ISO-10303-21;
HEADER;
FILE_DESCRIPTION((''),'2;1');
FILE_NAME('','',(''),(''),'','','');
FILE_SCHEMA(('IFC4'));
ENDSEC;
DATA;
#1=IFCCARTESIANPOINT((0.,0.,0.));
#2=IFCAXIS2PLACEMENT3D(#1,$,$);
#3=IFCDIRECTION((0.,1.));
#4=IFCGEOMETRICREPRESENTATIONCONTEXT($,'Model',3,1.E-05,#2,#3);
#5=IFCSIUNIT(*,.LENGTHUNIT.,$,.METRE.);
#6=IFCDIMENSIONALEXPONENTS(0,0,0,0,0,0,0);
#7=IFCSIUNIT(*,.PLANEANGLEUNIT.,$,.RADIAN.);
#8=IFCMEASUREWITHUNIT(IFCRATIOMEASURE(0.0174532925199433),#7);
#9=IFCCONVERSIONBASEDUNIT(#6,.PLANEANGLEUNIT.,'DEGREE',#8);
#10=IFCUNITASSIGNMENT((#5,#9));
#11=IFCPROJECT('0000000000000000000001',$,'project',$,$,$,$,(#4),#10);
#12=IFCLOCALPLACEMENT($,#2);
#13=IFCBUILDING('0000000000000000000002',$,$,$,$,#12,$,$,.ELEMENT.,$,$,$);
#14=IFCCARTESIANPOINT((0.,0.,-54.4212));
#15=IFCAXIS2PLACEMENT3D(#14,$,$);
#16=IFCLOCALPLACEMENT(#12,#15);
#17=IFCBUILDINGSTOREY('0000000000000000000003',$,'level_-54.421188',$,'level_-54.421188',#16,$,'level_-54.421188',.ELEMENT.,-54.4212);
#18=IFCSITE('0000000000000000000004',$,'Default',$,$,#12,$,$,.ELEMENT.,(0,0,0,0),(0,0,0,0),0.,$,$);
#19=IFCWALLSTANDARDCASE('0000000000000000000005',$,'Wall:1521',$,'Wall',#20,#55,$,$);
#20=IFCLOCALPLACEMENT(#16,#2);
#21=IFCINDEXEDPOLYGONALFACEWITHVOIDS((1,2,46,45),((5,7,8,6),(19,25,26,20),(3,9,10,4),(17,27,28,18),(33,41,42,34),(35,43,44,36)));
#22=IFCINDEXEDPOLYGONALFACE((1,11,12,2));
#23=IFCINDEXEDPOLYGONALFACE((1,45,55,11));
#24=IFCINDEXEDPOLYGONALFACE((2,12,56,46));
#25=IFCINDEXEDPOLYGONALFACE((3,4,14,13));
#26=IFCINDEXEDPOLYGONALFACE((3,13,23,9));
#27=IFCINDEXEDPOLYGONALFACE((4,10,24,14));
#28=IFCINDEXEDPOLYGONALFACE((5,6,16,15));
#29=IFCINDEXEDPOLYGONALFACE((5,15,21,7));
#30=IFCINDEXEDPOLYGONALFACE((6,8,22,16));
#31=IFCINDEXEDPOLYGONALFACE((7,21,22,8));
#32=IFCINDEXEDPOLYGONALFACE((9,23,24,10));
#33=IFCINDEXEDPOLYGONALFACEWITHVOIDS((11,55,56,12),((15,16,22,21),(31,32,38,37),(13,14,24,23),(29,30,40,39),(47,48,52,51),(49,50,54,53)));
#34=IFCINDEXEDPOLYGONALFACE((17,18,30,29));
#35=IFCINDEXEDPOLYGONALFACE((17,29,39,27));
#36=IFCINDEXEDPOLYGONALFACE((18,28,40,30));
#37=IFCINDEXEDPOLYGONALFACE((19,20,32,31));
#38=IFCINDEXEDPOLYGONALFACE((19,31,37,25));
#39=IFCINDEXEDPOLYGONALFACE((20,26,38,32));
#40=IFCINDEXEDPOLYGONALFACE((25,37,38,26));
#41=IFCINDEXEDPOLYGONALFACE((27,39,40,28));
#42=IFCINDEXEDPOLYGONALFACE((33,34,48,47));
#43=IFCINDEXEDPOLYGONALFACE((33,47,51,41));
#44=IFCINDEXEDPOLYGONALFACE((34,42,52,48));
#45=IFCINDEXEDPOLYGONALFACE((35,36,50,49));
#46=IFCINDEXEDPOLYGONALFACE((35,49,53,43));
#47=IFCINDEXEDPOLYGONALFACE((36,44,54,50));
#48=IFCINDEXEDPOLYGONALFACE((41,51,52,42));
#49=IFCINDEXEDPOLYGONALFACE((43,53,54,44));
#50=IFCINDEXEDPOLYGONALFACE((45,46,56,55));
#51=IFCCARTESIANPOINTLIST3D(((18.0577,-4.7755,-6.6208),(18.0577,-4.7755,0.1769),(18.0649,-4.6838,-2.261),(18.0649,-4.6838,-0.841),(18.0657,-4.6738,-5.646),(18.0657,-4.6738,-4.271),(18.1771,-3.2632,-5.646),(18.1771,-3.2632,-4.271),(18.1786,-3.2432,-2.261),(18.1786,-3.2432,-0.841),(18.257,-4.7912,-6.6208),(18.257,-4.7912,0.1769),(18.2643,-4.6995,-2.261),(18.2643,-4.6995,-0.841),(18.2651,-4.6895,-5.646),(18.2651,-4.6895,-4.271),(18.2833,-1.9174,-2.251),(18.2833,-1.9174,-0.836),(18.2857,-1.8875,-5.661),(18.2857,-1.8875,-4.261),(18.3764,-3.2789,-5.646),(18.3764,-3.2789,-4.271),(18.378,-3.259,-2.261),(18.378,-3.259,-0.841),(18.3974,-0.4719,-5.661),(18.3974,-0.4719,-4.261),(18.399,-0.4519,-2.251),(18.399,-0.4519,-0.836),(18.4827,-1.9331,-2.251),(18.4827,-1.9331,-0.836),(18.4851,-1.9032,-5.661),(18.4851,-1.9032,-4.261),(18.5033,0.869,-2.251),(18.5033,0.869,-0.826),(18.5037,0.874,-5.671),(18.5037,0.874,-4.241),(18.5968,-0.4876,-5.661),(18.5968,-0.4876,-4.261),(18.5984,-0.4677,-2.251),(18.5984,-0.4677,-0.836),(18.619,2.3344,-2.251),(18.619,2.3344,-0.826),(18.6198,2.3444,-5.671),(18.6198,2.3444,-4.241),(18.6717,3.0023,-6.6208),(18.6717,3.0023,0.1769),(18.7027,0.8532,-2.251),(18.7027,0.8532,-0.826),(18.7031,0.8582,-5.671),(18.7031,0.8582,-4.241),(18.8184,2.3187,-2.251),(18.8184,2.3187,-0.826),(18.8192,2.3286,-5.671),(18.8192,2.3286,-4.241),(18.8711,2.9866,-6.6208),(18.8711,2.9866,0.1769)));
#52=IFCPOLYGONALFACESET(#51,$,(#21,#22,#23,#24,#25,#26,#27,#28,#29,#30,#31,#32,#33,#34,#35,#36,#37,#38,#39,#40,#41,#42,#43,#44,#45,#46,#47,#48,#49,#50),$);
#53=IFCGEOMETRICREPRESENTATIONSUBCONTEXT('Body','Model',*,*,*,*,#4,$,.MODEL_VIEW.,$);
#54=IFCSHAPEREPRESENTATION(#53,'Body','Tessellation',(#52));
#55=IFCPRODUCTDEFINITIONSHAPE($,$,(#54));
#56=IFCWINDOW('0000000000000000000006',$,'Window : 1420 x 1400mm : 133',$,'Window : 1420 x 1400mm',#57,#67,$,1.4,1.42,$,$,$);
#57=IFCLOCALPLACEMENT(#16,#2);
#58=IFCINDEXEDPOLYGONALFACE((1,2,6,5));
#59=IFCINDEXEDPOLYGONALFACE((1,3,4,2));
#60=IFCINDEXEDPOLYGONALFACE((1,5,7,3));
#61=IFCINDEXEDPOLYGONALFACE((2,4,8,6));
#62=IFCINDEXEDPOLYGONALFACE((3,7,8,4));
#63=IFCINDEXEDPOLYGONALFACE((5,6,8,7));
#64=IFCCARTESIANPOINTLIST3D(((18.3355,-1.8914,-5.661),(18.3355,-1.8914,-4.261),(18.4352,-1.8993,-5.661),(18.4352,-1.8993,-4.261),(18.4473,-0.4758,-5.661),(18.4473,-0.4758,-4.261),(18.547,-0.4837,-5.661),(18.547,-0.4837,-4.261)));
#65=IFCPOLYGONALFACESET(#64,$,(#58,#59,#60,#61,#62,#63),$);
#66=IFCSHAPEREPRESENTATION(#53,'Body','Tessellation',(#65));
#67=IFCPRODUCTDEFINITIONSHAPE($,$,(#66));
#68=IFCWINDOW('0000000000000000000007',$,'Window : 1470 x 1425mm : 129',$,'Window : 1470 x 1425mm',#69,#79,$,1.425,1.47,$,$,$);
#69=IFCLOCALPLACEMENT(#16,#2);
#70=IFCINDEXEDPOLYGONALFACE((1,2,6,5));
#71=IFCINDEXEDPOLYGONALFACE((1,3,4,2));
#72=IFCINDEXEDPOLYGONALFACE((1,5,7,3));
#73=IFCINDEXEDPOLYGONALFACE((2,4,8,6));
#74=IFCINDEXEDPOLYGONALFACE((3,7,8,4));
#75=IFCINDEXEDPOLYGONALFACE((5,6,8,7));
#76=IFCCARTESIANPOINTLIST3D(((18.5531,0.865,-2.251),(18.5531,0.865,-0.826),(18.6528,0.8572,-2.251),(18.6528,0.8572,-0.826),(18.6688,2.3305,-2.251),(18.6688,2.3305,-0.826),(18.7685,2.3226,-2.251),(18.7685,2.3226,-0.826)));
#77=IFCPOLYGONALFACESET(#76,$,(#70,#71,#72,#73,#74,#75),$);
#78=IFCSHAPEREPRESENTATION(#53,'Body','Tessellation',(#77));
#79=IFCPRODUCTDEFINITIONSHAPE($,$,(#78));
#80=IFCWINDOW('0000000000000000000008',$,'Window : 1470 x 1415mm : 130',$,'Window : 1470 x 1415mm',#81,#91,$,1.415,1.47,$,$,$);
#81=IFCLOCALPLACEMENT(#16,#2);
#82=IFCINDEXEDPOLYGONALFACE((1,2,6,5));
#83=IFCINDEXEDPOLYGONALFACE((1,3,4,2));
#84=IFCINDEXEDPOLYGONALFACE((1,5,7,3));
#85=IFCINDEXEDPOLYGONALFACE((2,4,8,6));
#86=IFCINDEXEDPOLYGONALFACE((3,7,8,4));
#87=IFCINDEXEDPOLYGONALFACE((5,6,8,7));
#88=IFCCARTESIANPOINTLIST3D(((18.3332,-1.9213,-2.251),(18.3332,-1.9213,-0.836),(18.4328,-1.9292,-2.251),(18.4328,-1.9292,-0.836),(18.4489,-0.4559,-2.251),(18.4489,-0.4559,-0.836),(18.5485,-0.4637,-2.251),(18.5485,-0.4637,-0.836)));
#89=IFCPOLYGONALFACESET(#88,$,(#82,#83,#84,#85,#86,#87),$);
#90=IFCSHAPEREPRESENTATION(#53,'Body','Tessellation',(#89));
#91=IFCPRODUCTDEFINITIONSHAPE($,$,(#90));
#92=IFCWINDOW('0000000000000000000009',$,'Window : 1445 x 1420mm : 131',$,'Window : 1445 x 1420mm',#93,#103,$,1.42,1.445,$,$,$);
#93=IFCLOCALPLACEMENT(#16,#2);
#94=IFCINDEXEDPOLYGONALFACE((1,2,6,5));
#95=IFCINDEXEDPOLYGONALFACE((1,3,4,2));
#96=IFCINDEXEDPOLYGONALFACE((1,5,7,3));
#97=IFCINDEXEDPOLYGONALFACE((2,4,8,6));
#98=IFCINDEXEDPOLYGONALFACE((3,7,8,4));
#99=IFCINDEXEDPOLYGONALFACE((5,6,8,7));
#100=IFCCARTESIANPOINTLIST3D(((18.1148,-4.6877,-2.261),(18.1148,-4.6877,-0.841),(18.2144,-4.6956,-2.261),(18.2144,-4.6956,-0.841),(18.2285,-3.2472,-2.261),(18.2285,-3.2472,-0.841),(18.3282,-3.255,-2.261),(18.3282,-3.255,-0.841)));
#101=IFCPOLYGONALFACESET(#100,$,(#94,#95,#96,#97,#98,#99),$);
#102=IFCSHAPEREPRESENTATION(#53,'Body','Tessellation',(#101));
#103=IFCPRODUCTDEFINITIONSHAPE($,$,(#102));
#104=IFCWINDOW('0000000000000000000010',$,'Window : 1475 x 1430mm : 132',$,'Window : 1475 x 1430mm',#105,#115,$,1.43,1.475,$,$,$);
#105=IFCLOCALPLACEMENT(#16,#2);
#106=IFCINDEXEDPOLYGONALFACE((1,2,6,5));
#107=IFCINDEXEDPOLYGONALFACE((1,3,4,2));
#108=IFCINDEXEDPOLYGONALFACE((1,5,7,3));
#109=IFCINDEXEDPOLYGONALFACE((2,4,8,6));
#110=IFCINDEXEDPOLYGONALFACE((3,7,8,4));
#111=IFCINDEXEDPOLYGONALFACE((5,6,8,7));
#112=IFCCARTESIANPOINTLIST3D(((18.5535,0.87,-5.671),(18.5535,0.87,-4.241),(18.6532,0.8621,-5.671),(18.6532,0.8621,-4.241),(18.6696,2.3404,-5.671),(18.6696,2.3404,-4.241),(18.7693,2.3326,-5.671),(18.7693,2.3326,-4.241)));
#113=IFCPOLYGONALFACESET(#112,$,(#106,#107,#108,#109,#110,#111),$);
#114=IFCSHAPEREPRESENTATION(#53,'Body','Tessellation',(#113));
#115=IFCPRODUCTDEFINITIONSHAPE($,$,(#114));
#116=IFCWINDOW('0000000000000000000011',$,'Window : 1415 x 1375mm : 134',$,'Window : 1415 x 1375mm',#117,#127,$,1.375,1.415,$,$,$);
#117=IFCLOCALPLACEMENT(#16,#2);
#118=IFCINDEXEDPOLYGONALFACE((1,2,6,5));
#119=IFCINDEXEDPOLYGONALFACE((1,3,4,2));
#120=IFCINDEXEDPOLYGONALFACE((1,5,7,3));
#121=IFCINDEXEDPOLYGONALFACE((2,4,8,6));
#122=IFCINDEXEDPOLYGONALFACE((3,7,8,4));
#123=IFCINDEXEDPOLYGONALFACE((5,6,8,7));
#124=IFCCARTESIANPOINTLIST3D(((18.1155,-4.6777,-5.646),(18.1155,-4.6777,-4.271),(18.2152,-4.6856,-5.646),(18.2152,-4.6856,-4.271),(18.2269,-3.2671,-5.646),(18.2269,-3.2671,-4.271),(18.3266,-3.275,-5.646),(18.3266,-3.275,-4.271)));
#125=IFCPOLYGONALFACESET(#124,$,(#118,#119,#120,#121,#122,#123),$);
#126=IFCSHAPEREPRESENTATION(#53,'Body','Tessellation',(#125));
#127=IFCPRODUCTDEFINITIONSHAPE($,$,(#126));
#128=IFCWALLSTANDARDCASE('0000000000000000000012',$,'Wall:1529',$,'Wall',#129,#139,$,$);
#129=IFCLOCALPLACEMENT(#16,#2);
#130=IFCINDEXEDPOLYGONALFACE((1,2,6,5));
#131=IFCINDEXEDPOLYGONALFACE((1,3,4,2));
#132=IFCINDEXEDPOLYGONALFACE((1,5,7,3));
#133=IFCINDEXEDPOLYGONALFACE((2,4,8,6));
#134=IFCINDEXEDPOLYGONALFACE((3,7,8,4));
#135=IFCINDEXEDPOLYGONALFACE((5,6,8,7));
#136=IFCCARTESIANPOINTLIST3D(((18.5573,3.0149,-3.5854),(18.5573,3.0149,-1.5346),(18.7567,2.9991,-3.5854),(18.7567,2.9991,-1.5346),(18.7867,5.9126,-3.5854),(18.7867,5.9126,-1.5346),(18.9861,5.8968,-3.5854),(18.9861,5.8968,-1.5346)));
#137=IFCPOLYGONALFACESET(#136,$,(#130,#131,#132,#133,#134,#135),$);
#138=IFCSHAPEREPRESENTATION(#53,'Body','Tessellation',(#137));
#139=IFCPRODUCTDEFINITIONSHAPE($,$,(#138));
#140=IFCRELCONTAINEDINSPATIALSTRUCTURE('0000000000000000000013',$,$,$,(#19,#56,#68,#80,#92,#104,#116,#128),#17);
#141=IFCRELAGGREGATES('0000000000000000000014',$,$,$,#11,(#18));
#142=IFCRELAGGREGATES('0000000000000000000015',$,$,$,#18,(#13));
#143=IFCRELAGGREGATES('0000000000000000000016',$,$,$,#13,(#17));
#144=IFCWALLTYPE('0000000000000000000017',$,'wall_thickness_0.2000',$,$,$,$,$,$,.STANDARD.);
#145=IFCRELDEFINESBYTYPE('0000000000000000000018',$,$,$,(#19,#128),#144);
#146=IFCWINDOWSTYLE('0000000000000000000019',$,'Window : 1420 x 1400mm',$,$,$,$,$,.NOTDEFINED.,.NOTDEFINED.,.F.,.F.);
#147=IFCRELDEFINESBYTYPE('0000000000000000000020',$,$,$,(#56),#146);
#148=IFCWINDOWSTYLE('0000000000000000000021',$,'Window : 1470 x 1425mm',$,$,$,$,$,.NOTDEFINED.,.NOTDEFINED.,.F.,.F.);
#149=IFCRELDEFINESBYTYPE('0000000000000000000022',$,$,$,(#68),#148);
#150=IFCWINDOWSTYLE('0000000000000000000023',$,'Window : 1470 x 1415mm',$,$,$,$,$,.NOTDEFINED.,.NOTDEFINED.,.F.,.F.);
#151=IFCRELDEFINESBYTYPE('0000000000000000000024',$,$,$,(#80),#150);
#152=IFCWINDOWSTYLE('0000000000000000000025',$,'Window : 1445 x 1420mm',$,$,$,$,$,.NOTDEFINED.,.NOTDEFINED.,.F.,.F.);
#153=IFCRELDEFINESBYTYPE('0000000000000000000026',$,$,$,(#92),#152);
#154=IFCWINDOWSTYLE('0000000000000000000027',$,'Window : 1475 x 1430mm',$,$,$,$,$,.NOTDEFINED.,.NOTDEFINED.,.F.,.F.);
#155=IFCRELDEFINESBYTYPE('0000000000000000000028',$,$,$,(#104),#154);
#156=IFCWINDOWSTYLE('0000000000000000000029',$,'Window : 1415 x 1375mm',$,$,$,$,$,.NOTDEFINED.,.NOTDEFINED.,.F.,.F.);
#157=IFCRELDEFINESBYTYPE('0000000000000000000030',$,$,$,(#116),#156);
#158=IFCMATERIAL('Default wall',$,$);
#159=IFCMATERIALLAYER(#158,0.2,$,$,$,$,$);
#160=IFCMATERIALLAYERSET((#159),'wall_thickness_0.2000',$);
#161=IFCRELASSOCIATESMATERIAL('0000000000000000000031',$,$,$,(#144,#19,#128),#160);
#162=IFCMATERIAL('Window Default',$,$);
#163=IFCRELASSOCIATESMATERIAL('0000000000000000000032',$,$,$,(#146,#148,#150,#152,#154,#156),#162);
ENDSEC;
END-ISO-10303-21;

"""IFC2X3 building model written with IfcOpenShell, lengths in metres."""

from ifc_helpers import new_model, entity, si_unit, converted_unit, direction, frame, frame_2d, origin, origin_2d_with_axis, place, context, subcontext, project, spatial, polyline, rectangle, outline, extrude, source, transform, mapped, material, layer, layer_set, layer_usage, type_object, type_shapes, element, fill, save


model = new_model("IFC2X3")

# Units and contexts
model_context = context("Model", 3, precision=1e-05, world=origin(), true_north=direction((0.0, 1.0)))
body_context = subcontext(model_context, "Body", "Model", "MODEL_VIEW")
ifc_project = project(units=[si_unit("LENGTHUNIT", "METRE"), converted_unit("PLANEANGLEUNIT", "DEGREE", entity("IfcRatioMeasure", 0.0174532925199433), si_unit("PLANEANGLEUNIT", "RADIAN"), dimensions=[0, 0, 0, 0, 0, 0, 0])], contexts=[model_context])

# Site, building, storey
placement_1 = place(None, origin())
site = spatial("IfcSite", under=ifc_project, at=placement_1, Name="Default", CompositionType="ELEMENT", RefLatitude=(0, 0, 0, 0), RefLongitude=(0, 0, 0, 0), RefElevation=0.0)
building = spatial("IfcBuilding", under=site, at=placement_1, CompositionType="ELEMENT")
storey_placement = place(placement_1, frame((0.0, 0.0, -54.4212)))
storey = spatial("IfcBuildingStorey", under=building, at=storey_placement, Name="level_-54.421188", ObjectType="level_-54.421188", LongName="level_-54.421188", CompositionType="ELEMENT", Elevation=-54.4212)

# Shared definitions
ifc_material_1 = material(Name="Default wall")
ifc_layer = layer(ifc_material_1, 0.2)
ifc_layer_set = layer_set([ifc_layer], Name="wall_thickness_0.2000")
ifc_layer_usage = layer_usage(ifc_layer_set, "AXIS2", "POSITIVE", -0.1)
wall_type = type_object("IfcWallType", Name="wall_thickness_0.2000", PredefinedType="STANDARD", material=ifc_layer_set)
ifc_material_2 = material(Name="Window Default")

# Wall, openings, windows
placement_2 = place(placement_1, frame((0.0, 0.0, -61.042)))
wall_1_placement = place(placement_2, frame((18.7714, 2.9945, 0.0), z_axis=(0.0, 0.0, 1.0), x_axis=(-0.078706, -0.996898, 0.0)))
wall_1 = element("IfcWallStandardCase", 1, at=wall_1_placement, inside=storey, type_object=wall_type, material=ifc_layer_usage, Name="Wall:1521", ObjectType="Wall", context=body_context, shape_type="SweptSolid", body=[
    extrude(outline(polyline([(7.802, -0.1), (7.802, 0.1), (0.0, 0.1), (0.0, -0.1), (7.802, -0.1)])), origin(), (0.0, 0.0, 1.0), 6.7978),
])
opening_1_placement = place(wall_1_placement, frame((0.67, -0.1, 4.3698)))
opening_1 = element("IfcOpeningElement", 2, at=opening_1_placement, cuts=wall_1, ObjectType="Opening", context=body_context, shape_type="SweptSolid", body=[
    extrude(rectangle(XDim=1.47, YDim=1.425, at=frame_2d((0.7125, 0.735), x_axis=(0.0, 1.0))), frame((0.0, 0.0, 0.0), z_axis=(0.0, 1.0, 0.0), x_axis=(0.0, 0.0, 1.0)), (0.0, 0.0, 1.0), 0.2),
])
opening_2_placement = place(wall_1_placement, frame((3.465, -0.1, 4.3698)))
opening_2 = element("IfcOpeningElement", 3, at=opening_2_placement, cuts=wall_1, ObjectType="Opening", context=body_context, shape_type="SweptSolid", body=[
    extrude(rectangle(XDim=1.47, YDim=1.415, at=frame_2d((0.7075, 0.735), x_axis=(0.0, 1.0))), frame((0.0, 0.0, 0.0), z_axis=(0.0, 1.0, 0.0), x_axis=(0.0, 0.0, 1.0)), (0.0, 0.0, 1.0), 0.2),
])
opening_3_placement = place(wall_1_placement, frame((6.265, -0.1, 4.3598)))
opening_3 = element("IfcOpeningElement", 4, at=opening_3_placement, cuts=wall_1, ObjectType="Opening", context=body_context, shape_type="SweptSolid", body=[
    extrude(rectangle(XDim=1.445, YDim=1.42, at=frame_2d((0.71, 0.7225), x_axis=(0.0, 1.0))), frame((0.0, 0.0, 0.0), z_axis=(0.0, 1.0, 0.0), x_axis=(0.0, 0.0, 1.0)), (0.0, 0.0, 1.0), 0.2),
])
opening_4_placement = place(wall_1_placement, frame((0.66, -0.1, 0.9498)))
opening_4 = element("IfcOpeningElement", 5, at=opening_4_placement, cuts=wall_1, ObjectType="Opening", context=body_context, shape_type="SweptSolid", body=[
    extrude(rectangle(XDim=1.475, YDim=1.43, at=frame_2d((0.715, 0.7375), x_axis=(0.0, 1.0))), frame((0.0, 0.0, 0.0), z_axis=(0.0, 1.0, 0.0), x_axis=(0.0, 0.0, 1.0)), (0.0, 0.0, 1.0), 0.2),
])
opening_5_placement = place(wall_1_placement, frame((3.485, -0.1, 0.9599)))
opening_5 = element("IfcOpeningElement", 6, at=opening_5_placement, cuts=wall_1, ObjectType="Opening", context=body_context, shape_type="SweptSolid", body=[
    extrude(rectangle(XDim=1.42, YDim=1.4, at=frame_2d((0.7, 0.71), x_axis=(0.0, 1.0))), frame((0.0, 0.0, 0.0), z_axis=(0.0, 1.0, 0.0), x_axis=(0.0, 0.0, 1.0)), (0.0, 0.0, 1.0), 0.2),
])
opening_6_placement = place(wall_1_placement, frame((6.285, -0.1, 0.9748)))
opening_6 = element("IfcOpeningElement", 7, at=opening_6_placement, cuts=wall_1, ObjectType="Opening", context=body_context, shape_type="SweptSolid", body=[
    extrude(rectangle(XDim=1.415, YDim=1.375, at=frame_2d((0.6875, 0.7075), x_axis=(0.0, 1.0))), frame((0.0, 0.0, 0.0), z_axis=(0.0, 1.0, 0.0), x_axis=(0.0, 0.0, 1.0)), (0.0, 0.0, 1.0), 0.2),
])
window_style_1 = type_object("IfcWindowStyle", Name="Window : 1420 x 1400mm", ConstructionType="NOTDEFINED", OperationType="NOTDEFINED", ParameterTakesPrecedence=False, Sizeable=False, material=ifc_material_2)
shared_shape_1 = source(origin(), body_context, "Body", "SweptSolid", [
    extrude(rectangle(XDim=0.1, YDim=1.42, at=origin_2d_with_axis()), frame((0.71, 0.1, 0.0), z_axis=(0.0, 0.0, 1.0), x_axis=(0.0, 1.0, 0.0)), (0.0, 0.0, 1.0), 1.4),
])
type_shapes(window_style_1, [shared_shape_1])
window_1_placement = place(opening_5_placement, origin())
window_1 = element("IfcWindow", 8, at=window_1_placement, inside=storey, type_object=window_style_1, Name="Window : 1420 x 1400mm : 133", ObjectType="Window : 1420 x 1400mm", OverallHeight=1.4, OverallWidth=1.42, context=body_context, shape_type="MappedRepresentation", body=[
    mapped(shared_shape_1, transform((0.0, 0.0, 0.0), scale=1.0)),
])
fill(opening_5, window_1)
window_style_2 = type_object("IfcWindowStyle", Name="Window : 1470 x 1425mm", ConstructionType="NOTDEFINED", OperationType="NOTDEFINED", ParameterTakesPrecedence=False, Sizeable=False, material=ifc_material_2)
shared_shape_2 = source(origin(), body_context, "Body", "SweptSolid", [
    extrude(rectangle(XDim=0.1, YDim=1.47, at=origin_2d_with_axis()), frame((0.735, 0.1, 0.0), z_axis=(0.0, 0.0, 1.0), x_axis=(0.0, 1.0, 0.0)), (0.0, 0.0, 1.0), 1.425),
])
type_shapes(window_style_2, [shared_shape_2])
window_2_placement = place(opening_1_placement, origin())
window_2 = element("IfcWindow", 9, at=window_2_placement, inside=storey, type_object=window_style_2, Name="Window : 1470 x 1425mm : 129", ObjectType="Window : 1470 x 1425mm", OverallHeight=1.425, OverallWidth=1.47, context=body_context, shape_type="MappedRepresentation", body=[
    mapped(shared_shape_2, transform((0.0, 0.0, 0.0), scale=1.0)),
])
fill(opening_1, window_2)
window_style_3 = type_object("IfcWindowStyle", Name="Window : 1470 x 1415mm", ConstructionType="NOTDEFINED", OperationType="NOTDEFINED", ParameterTakesPrecedence=False, Sizeable=False, material=ifc_material_2)
shared_shape_3 = source(origin(), body_context, "Body", "SweptSolid", [
    extrude(rectangle(XDim=0.1, YDim=1.47, at=origin_2d_with_axis()), frame((0.735, 0.1, 0.0), z_axis=(0.0, 0.0, 1.0), x_axis=(0.0, 1.0, 0.0)), (0.0, 0.0, 1.0), 1.415),
])
type_shapes(window_style_3, [shared_shape_3])
window_3_placement = place(opening_2_placement, origin())
window_3 = element("IfcWindow", 10, at=window_3_placement, inside=storey, type_object=window_style_3, Name="Window : 1470 x 1415mm : 130", ObjectType="Window : 1470 x 1415mm", OverallHeight=1.415, OverallWidth=1.47, context=body_context, shape_type="MappedRepresentation", body=[
    mapped(shared_shape_3, transform((0.0, 0.0, 0.0), scale=1.0)),
])
fill(opening_2, window_3)
window_style_4 = type_object("IfcWindowStyle", Name="Window : 1445 x 1420mm", ConstructionType="NOTDEFINED", OperationType="NOTDEFINED", ParameterTakesPrecedence=False, Sizeable=False, material=ifc_material_2)
shared_shape_4 = source(origin(), body_context, "Body", "SweptSolid", [
    extrude(rectangle(XDim=0.1, YDim=1.445, at=origin_2d_with_axis()), frame((0.7225, 0.1, 0.0), z_axis=(0.0, 0.0, 1.0), x_axis=(0.0, 1.0, 0.0)), (0.0, 0.0, 1.0), 1.42),
])
type_shapes(window_style_4, [shared_shape_4])
window_4_placement = place(opening_3_placement, origin())
window_4 = element("IfcWindow", 11, at=window_4_placement, inside=storey, type_object=window_style_4, Name="Window : 1445 x 1420mm : 131", ObjectType="Window : 1445 x 1420mm", OverallHeight=1.42, OverallWidth=1.445, context=body_context, shape_type="MappedRepresentation", body=[
    mapped(shared_shape_4, transform((0.0, 0.0, 0.0), scale=1.0)),
])
fill(opening_3, window_4)
window_style_5 = type_object("IfcWindowStyle", Name="Window : 1475 x 1430mm", ConstructionType="NOTDEFINED", OperationType="NOTDEFINED", ParameterTakesPrecedence=False, Sizeable=False, material=ifc_material_2)
shared_shape_5 = source(origin(), body_context, "Body", "SweptSolid", [
    extrude(rectangle(XDim=0.1, YDim=1.475, at=origin_2d_with_axis()), frame((0.7375, 0.1, 0.0), z_axis=(0.0, 0.0, 1.0), x_axis=(0.0, 1.0, 0.0)), (0.0, 0.0, 1.0), 1.43),
])
type_shapes(window_style_5, [shared_shape_5])
window_5_placement = place(opening_4_placement, origin())
window_5 = element("IfcWindow", 12, at=window_5_placement, inside=storey, type_object=window_style_5, Name="Window : 1475 x 1430mm : 132", ObjectType="Window : 1475 x 1430mm", OverallHeight=1.43, OverallWidth=1.475, context=body_context, shape_type="MappedRepresentation", body=[
    mapped(shared_shape_5, transform((0.0, 0.0, 0.0), scale=1.0)),
])
fill(opening_4, window_5)
window_style_6 = type_object("IfcWindowStyle", Name="Window : 1415 x 1375mm", ConstructionType="NOTDEFINED", OperationType="NOTDEFINED", ParameterTakesPrecedence=False, Sizeable=False, material=ifc_material_2)
shared_shape_6 = source(origin(), body_context, "Body", "SweptSolid", [
    extrude(rectangle(XDim=0.1, YDim=1.415, at=origin_2d_with_axis()), frame((0.7075, 0.1, 0.0), z_axis=(0.0, 0.0, 1.0), x_axis=(0.0, 1.0, 0.0)), (0.0, 0.0, 1.0), 1.375),
])
type_shapes(window_style_6, [shared_shape_6])
window_6_placement = place(opening_6_placement, origin())
window_6 = element("IfcWindow", 13, at=window_6_placement, inside=storey, type_object=window_style_6, Name="Window : 1415 x 1375mm : 134", ObjectType="Window : 1415 x 1375mm", OverallHeight=1.375, OverallWidth=1.415, context=body_context, shape_type="MappedRepresentation", body=[
    mapped(shared_shape_6, transform((0.0, 0.0, 0.0), scale=1.0)),
])
fill(opening_6, window_6)

# Wall
placement_3 = place(placement_1, frame((0.0, 0.0, -58.0066)))
wall_2_placement = place(placement_3, frame((18.8864, 5.9047, 0.0), z_axis=(0.0, 0.0, 1.0), x_axis=(-0.078925, -0.996881, 0.0)))
element("IfcWallStandardCase", 14, at=wall_2_placement, inside=storey, type_object=wall_type, material=ifc_layer_usage, Name="Wall:1529", ObjectType="Wall", context=body_context, shape_type="SweptSolid", body=[
    extrude(outline(polyline([(2.9068, -0.1), (2.9068, 0.1), (0.0, 0.1), (0.0, -0.1), (2.9068, -0.1)])), origin(), (0.0, 0.0, 1.0), 2.0508),
])

save(model, "model.ifc")
